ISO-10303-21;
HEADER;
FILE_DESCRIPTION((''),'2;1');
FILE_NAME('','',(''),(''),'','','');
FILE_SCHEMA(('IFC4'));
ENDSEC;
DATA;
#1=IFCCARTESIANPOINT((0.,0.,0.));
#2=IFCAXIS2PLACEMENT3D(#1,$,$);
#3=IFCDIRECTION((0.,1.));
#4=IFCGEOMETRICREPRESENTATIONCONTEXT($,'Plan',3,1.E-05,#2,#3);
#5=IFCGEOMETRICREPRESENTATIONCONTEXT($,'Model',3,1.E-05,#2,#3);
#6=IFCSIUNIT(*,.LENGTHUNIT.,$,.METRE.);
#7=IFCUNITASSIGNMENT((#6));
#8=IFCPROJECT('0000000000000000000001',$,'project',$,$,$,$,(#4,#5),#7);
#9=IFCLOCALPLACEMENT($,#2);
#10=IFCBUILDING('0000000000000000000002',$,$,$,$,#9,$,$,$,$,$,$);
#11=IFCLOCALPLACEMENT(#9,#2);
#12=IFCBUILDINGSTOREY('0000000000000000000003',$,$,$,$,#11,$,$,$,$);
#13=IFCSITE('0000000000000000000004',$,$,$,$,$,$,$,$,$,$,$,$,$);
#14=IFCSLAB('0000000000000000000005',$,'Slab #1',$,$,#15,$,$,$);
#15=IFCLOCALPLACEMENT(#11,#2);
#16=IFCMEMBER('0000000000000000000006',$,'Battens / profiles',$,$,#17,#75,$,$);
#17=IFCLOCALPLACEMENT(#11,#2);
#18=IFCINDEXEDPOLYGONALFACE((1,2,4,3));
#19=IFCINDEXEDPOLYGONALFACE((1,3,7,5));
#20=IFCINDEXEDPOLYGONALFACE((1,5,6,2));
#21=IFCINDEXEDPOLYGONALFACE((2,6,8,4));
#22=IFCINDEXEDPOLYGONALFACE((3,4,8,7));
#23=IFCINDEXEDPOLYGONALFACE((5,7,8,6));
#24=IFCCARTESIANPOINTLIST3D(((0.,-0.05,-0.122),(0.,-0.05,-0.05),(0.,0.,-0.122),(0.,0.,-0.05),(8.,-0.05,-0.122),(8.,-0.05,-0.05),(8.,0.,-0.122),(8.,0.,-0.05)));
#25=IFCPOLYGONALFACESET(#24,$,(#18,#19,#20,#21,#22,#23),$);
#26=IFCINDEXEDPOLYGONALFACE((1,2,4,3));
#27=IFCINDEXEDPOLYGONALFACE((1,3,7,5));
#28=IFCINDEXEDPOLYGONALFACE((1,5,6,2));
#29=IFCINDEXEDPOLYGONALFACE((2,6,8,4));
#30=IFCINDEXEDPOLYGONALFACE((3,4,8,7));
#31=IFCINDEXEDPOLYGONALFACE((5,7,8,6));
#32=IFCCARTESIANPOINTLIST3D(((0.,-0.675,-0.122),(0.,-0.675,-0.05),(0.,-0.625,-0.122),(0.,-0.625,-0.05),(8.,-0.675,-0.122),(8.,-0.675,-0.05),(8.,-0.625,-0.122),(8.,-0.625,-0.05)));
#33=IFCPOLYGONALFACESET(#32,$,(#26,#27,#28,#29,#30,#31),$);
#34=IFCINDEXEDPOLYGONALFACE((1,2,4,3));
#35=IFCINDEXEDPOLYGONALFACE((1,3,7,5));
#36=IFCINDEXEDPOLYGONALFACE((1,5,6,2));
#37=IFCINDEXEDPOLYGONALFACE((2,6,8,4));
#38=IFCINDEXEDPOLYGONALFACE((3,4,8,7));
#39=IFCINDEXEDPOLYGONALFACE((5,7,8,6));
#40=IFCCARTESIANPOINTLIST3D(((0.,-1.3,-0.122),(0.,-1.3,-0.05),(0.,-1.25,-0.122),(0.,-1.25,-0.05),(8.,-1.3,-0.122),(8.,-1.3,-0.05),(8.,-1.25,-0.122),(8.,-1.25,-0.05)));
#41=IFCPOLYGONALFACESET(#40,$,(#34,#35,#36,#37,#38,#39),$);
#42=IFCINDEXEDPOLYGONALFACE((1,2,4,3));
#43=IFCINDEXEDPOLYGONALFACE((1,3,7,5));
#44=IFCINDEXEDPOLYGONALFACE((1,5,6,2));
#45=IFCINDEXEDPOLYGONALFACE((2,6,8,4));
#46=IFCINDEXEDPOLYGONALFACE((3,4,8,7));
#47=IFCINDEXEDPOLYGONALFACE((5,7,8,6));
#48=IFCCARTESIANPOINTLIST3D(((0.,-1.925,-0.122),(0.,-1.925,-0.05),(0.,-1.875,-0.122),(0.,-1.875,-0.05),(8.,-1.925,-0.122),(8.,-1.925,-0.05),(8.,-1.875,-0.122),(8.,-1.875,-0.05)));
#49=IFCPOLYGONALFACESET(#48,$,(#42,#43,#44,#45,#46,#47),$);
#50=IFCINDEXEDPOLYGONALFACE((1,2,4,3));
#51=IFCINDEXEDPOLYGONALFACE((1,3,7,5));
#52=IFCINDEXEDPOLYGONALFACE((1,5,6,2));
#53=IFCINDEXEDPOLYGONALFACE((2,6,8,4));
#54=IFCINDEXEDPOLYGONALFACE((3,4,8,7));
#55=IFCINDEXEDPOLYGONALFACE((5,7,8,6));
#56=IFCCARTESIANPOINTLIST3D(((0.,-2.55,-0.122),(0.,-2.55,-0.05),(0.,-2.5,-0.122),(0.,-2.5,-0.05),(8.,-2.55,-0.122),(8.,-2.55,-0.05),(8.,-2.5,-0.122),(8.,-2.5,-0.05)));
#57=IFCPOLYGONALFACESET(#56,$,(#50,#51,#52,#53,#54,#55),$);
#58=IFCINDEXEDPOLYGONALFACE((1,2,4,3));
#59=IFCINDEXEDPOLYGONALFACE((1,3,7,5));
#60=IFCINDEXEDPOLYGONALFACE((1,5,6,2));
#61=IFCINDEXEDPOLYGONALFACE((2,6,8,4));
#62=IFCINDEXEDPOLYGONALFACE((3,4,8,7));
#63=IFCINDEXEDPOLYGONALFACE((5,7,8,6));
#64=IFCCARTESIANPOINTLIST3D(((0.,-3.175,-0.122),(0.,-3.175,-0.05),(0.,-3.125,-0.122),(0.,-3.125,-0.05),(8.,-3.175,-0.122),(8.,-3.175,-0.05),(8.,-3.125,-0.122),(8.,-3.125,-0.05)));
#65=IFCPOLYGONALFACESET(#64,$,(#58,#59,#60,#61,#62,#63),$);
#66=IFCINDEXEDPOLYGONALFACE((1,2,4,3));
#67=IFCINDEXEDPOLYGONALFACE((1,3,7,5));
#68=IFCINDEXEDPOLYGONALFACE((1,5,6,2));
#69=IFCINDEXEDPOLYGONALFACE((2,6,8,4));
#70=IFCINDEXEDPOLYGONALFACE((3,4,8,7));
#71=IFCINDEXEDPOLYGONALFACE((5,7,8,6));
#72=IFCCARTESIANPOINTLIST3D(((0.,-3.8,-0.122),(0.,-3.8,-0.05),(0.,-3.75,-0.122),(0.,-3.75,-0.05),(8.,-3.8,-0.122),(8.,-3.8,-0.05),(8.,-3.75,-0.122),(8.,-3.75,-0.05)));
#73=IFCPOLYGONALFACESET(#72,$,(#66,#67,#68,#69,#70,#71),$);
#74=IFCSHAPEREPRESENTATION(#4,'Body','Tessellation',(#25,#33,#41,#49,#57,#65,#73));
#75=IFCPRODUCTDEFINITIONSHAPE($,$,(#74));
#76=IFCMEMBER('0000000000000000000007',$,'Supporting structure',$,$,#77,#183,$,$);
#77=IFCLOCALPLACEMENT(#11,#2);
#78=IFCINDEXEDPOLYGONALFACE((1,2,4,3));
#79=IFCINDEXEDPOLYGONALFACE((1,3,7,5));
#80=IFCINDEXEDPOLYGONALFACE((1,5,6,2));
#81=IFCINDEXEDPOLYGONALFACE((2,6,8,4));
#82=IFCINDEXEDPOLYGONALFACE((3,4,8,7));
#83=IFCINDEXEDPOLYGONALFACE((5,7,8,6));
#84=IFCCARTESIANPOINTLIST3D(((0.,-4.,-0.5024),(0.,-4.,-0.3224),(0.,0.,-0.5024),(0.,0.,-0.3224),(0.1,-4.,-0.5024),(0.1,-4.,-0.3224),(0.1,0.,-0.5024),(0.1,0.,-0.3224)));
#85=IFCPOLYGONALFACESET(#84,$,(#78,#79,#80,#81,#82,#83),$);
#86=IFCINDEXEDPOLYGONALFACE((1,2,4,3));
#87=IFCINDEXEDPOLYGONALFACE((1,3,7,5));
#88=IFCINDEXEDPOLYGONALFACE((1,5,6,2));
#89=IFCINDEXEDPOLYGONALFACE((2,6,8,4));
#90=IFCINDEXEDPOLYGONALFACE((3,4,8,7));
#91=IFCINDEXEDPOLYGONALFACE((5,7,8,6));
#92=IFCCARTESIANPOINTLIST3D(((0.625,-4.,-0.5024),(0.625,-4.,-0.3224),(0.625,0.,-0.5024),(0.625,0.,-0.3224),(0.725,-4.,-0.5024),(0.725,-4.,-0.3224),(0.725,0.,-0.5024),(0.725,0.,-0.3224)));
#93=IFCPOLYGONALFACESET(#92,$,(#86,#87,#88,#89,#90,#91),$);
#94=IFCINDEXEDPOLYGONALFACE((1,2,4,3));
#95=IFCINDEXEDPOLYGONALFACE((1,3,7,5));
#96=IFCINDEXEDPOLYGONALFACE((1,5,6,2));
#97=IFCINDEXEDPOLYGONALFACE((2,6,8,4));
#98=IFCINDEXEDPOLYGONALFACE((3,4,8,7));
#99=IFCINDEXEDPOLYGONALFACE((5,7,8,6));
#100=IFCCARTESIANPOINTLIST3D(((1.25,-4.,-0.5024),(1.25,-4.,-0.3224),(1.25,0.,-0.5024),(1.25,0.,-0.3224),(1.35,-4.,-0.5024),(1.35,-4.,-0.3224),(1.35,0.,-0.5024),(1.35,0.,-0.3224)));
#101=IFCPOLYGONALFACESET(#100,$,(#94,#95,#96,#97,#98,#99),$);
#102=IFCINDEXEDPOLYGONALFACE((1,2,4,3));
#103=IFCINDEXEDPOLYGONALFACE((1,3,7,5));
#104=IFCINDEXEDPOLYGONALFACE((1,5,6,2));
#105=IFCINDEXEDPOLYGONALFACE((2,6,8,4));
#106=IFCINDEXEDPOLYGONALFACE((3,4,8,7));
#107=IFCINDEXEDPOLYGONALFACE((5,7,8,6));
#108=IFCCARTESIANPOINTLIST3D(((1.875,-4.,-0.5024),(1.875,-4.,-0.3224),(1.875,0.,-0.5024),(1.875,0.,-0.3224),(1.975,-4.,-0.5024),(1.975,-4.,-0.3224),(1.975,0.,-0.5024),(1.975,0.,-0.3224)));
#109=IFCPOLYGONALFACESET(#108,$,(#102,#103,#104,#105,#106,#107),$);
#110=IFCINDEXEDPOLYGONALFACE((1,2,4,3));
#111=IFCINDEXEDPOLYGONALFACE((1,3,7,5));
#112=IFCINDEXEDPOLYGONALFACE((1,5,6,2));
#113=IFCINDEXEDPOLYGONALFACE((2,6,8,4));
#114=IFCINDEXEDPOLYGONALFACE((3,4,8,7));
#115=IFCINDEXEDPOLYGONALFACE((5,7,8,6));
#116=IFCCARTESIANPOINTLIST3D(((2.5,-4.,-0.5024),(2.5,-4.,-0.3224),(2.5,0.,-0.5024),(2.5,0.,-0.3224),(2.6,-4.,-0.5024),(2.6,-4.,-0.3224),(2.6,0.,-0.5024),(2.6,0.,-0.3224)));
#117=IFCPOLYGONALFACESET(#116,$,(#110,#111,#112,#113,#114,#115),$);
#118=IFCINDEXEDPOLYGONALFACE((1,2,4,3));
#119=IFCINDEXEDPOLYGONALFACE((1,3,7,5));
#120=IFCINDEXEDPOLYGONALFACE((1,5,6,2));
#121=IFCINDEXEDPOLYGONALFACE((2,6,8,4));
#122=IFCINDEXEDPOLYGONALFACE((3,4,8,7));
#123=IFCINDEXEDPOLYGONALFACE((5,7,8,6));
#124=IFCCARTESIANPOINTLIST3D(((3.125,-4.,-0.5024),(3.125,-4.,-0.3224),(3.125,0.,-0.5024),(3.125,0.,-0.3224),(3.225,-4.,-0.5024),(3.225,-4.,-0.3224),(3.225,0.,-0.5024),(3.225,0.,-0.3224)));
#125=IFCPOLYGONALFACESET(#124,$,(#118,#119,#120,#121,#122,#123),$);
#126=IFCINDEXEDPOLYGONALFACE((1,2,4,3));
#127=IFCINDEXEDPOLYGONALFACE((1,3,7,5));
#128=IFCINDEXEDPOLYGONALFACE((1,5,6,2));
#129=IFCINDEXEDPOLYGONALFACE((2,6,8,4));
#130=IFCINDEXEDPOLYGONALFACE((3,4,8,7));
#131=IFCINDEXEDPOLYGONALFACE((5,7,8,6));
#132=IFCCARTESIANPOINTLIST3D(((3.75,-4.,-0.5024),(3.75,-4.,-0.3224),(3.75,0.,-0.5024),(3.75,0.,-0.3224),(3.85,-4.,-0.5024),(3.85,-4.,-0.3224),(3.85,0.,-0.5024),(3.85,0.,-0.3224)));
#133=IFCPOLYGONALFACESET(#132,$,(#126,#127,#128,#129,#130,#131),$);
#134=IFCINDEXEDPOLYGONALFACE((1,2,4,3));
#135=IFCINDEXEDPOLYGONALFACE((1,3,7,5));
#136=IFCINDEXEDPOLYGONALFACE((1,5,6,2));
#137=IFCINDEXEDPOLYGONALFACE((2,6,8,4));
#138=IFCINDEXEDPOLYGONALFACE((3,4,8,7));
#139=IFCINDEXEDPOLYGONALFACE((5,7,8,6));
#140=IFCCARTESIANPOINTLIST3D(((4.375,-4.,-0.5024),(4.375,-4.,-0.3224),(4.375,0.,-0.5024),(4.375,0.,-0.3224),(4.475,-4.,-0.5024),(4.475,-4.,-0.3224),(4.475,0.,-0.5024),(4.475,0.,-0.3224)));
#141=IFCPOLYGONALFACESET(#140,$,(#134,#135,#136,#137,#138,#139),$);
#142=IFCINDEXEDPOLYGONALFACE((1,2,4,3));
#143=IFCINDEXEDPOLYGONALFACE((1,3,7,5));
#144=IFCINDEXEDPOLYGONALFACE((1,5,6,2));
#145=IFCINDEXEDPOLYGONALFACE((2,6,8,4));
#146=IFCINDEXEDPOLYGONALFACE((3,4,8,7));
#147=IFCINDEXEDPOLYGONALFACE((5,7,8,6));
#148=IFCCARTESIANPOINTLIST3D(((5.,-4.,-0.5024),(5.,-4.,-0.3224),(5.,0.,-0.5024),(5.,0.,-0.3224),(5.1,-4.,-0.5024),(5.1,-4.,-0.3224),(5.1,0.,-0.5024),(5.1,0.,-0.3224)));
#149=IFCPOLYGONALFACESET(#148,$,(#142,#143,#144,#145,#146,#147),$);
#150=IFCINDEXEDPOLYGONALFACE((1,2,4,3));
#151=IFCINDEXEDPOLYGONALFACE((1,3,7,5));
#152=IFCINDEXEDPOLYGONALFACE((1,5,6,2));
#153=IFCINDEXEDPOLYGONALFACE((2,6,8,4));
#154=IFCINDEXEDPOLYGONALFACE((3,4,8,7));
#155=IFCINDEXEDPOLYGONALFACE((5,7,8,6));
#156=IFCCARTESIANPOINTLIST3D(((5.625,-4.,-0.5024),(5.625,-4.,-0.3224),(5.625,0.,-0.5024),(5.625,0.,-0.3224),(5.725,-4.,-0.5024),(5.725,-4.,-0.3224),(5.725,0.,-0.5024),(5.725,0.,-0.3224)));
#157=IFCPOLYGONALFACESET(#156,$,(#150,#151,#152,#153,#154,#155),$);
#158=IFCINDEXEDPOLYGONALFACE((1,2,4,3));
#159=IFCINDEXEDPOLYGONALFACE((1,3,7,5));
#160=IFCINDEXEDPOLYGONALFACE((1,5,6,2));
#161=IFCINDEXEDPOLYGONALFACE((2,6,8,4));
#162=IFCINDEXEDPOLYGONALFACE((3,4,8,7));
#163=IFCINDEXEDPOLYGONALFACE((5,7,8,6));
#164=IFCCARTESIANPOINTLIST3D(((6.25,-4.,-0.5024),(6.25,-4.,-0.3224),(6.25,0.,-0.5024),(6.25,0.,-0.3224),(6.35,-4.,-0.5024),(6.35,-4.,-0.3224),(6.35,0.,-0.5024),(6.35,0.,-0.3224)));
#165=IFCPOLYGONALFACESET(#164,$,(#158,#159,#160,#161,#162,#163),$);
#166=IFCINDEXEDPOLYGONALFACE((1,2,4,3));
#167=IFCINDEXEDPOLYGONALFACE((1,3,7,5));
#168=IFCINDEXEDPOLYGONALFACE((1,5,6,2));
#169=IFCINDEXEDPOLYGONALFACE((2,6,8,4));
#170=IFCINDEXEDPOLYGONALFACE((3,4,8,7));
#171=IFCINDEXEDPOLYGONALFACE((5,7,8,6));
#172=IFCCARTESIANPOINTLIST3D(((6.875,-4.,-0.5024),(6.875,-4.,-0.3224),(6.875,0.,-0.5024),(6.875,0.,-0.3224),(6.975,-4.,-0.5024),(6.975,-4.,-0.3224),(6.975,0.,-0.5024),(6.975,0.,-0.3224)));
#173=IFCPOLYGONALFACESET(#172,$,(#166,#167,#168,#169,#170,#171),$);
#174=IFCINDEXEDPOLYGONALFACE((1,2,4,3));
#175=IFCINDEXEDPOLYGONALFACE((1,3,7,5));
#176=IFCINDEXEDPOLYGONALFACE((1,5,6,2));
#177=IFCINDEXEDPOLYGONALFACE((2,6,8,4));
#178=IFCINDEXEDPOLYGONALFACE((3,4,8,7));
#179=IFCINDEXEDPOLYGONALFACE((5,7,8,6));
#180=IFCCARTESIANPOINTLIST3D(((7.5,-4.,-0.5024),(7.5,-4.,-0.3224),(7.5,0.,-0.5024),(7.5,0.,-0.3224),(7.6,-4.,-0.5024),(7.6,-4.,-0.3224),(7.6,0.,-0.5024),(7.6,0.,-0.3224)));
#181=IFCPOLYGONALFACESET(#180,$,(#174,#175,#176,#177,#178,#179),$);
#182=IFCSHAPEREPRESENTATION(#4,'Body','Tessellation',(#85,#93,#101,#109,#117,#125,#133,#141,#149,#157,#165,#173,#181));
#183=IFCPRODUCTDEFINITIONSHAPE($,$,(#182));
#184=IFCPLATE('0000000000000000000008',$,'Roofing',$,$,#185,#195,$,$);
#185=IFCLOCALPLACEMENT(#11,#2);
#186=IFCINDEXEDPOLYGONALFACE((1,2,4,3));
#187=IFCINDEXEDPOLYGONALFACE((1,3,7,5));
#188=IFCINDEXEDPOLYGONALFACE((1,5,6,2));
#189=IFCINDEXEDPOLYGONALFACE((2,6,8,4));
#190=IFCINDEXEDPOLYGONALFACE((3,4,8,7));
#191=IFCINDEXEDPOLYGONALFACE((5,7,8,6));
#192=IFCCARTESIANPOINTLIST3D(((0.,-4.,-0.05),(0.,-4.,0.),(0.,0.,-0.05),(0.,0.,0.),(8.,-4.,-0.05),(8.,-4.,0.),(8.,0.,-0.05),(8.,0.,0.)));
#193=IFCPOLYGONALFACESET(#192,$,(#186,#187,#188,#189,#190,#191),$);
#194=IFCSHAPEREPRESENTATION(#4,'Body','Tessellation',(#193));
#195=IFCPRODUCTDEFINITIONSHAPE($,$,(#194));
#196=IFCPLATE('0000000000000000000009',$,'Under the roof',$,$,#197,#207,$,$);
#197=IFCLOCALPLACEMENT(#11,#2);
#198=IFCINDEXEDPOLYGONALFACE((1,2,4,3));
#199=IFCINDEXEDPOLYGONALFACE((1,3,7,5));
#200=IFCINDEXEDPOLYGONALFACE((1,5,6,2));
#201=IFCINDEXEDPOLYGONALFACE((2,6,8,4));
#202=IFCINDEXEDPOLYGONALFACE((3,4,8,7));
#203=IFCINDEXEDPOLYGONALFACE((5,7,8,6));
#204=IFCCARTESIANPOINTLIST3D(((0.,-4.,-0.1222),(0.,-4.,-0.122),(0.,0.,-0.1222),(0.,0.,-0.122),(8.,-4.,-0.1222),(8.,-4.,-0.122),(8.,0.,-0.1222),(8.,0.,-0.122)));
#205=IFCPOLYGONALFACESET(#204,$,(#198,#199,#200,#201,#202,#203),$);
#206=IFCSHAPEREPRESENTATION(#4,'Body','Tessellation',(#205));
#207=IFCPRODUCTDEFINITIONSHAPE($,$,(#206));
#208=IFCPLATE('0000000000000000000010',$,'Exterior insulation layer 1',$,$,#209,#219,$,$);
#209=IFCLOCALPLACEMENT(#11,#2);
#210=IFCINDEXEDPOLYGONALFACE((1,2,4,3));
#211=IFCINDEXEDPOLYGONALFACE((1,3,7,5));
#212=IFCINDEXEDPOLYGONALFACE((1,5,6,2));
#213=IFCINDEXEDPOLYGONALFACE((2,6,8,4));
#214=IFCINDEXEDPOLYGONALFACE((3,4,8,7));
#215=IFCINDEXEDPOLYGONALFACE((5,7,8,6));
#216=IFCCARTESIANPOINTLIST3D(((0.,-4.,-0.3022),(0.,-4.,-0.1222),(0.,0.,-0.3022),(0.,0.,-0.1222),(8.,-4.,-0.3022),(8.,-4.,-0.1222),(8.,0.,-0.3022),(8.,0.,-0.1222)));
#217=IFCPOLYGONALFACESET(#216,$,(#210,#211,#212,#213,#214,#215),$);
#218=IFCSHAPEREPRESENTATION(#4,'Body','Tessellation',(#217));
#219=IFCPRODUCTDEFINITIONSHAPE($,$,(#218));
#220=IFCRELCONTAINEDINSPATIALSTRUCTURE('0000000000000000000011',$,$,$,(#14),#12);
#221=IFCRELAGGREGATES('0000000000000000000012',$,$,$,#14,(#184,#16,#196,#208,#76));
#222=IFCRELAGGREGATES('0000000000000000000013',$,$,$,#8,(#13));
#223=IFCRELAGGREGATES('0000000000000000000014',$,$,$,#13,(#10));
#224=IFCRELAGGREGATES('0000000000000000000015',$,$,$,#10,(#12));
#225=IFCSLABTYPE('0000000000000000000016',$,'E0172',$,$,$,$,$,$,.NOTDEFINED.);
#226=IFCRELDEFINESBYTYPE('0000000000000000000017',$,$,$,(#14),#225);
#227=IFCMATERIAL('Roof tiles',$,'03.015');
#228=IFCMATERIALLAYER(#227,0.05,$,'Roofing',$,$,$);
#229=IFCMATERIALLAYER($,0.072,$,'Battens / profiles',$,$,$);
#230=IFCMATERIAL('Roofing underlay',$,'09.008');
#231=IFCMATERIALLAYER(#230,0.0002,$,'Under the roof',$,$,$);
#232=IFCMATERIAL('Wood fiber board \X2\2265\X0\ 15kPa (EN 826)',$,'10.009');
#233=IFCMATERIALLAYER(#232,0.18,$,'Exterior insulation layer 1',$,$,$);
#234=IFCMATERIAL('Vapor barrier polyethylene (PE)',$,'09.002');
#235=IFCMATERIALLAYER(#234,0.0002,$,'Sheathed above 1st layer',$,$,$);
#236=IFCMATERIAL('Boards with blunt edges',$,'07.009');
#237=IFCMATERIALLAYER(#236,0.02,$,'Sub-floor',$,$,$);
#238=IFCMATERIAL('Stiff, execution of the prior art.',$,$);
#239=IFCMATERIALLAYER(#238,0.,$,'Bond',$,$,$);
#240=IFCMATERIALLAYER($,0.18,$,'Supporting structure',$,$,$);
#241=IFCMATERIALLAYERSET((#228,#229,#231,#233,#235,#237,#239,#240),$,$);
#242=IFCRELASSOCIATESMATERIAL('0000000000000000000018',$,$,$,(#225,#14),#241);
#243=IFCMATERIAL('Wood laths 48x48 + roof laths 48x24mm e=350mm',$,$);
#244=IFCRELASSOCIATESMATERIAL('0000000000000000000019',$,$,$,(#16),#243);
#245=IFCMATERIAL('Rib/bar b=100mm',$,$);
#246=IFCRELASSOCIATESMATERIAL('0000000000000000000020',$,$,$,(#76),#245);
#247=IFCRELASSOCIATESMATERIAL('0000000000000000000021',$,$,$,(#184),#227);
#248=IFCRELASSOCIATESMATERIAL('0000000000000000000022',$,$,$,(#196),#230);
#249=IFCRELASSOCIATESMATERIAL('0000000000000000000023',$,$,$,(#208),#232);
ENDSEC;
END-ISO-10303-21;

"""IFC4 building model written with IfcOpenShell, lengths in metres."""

from ifc_helpers import new_model, si_unit, direction, frame, frame_2d, origin, origin_with_axes, place, context, project, spatial, rectangle, extrude, material, layer, layer_set, type_object, element, aggregate, save


model = new_model("IFC4")

# Units and contexts
plan_context = context("Plan", 3, precision=1e-05, world=origin(), true_north=direction((0.0, 1.0)))
model_context = context("Model", 3, precision=1e-05, world=origin(), true_north=direction((0.0, 1.0)))
ifc_project = project(units=[si_unit("LENGTHUNIT", "METRE")], contexts=[plan_context, model_context])

# Site, building, storey
site = spatial("IfcSite", under=ifc_project)
building_placement = place(None, origin())
building = spatial("IfcBuilding", under=site, at=building_placement)
storey_placement = place(building_placement, origin())
storey = spatial("IfcBuildingStorey", under=building, at=storey_placement)

# Slab, members, plates
ifc_material_1 = material(Name="Roof tiles", Category="03.015")
ifc_layer_1 = layer(ifc_material_1, 0.05, Name="Roofing")
ifc_layer_2 = layer(None, 0.072, Name="Battens / profiles")
ifc_material_2 = material(Name="Roofing underlay", Category="09.008")
ifc_layer_3 = layer(ifc_material_2, 0.0002, Name="Under the roof")
ifc_material_3 = material(Name="Wood fiber board ≥ 15kPa (EN 826)", Category="10.009")
ifc_layer_4 = layer(ifc_material_3, 0.18, Name="Exterior insulation layer 1")
ifc_material_4 = material(Name="Vapor barrier polyethylene (PE)", Category="09.002")
ifc_layer_5 = layer(ifc_material_4, 0.0002, Name="Sheathed above 1st layer")
ifc_material_5 = material(Name="Boards with blunt edges", Category="07.009")
ifc_layer_6 = layer(ifc_material_5, 0.02, Name="Sub-floor")
ifc_material_6 = material(Name="Stiff, execution of the prior art.")
ifc_layer_7 = layer(ifc_material_6, 0.0, Name="Bond")
ifc_layer_8 = layer(None, 0.18, Name="Supporting structure")
ifc_layer_set = layer_set([ifc_layer_1, ifc_layer_2, ifc_layer_3, ifc_layer_4, ifc_layer_5, ifc_layer_6, ifc_layer_7, ifc_layer_8])
slab_type = type_object("IfcSlabType", Name="E0172", PredefinedType="NOTDEFINED", material=ifc_layer_set)
slab_placement = place(None, frame((0.0, 0.0, 0.0), z_axis=(0.0, 0.0, -1.0), x_axis=(1.0, 0.0, 0.0)))
slab = element("IfcSlab", 1, at=slab_placement, inside=storey, type_object=slab_type, material=ifc_layer_set, Name="Slab #1")
ifc_material_7 = material(Name="Wood laths 48x48 + roof laths 48x24mm e=350mm")
member_1_placement = place(slab_placement, origin())
member_1 = element("IfcMember", 2, at=member_1_placement, material=ifc_material_7, Name="Battens / profiles", context=plan_context, shape_type="SweptSolid", body=[
    extrude(rectangle(XDim=0.05, YDim=0.072, at=frame_2d((0.025, 0.036), x_axis=(1.0, 0.0))), frame((0.0, 0.0, 0.05), z_axis=(1.0, 0.0, 0.0), x_axis=(0.0, 1.0, 0.0)), (0.0, 0.0, 1.0), 8.0),
    extrude(rectangle(XDim=0.05, YDim=0.072, at=frame_2d((0.025, 0.036), x_axis=(1.0, 0.0))), frame((0.0, 0.625, 0.05), z_axis=(1.0, 0.0, 0.0), x_axis=(0.0, 1.0, 0.0)), (0.0, 0.0, 1.0), 8.0),
    extrude(rectangle(XDim=0.05, YDim=0.072, at=frame_2d((0.025, 0.036), x_axis=(1.0, 0.0))), frame((0.0, 1.25, 0.05), z_axis=(1.0, 0.0, 0.0), x_axis=(0.0, 1.0, 0.0)), (0.0, 0.0, 1.0), 8.0),
    extrude(rectangle(XDim=0.05, YDim=0.072, at=frame_2d((0.025, 0.036), x_axis=(1.0, 0.0))), frame((0.0, 1.875, 0.05), z_axis=(1.0, 0.0, 0.0), x_axis=(0.0, 1.0, 0.0)), (0.0, 0.0, 1.0), 8.0),
    extrude(rectangle(XDim=0.05, YDim=0.072, at=frame_2d((0.025, 0.036), x_axis=(1.0, 0.0))), frame((0.0, 2.5, 0.05), z_axis=(1.0, 0.0, 0.0), x_axis=(0.0, 1.0, 0.0)), (0.0, 0.0, 1.0), 8.0),
    extrude(rectangle(XDim=0.05, YDim=0.072, at=frame_2d((0.025, 0.036), x_axis=(1.0, 0.0))), frame((0.0, 3.125, 0.05), z_axis=(1.0, 0.0, 0.0), x_axis=(0.0, 1.0, 0.0)), (0.0, 0.0, 1.0), 8.0),
    extrude(rectangle(XDim=0.05, YDim=0.072, at=frame_2d((0.025, 0.036), x_axis=(1.0, 0.0))), frame((0.0, 3.75, 0.05), z_axis=(1.0, 0.0, 0.0), x_axis=(0.0, 1.0, 0.0)), (0.0, 0.0, 1.0), 8.0),
])
ifc_material_8 = material(Name="Rib/bar b=100mm")
member_2_placement = place(slab_placement, origin())
member_2 = element("IfcMember", 3, at=member_2_placement, material=ifc_material_8, Name="Supporting structure", context=plan_context, shape_type="SweptSolid", body=[
    extrude(rectangle(XDim=0.1, YDim=0.18, at=frame_2d((0.05, 0.09), x_axis=(1.0, 0.0))), frame((0.0, 4.0, 0.3224), z_axis=(0.0, -1.0, 0.0), x_axis=(1.0, 0.0, 0.0)), (0.0, 0.0, 1.0), 4.0),
    extrude(rectangle(XDim=0.1, YDim=0.18, at=frame_2d((0.05, 0.09), x_axis=(1.0, 0.0))), frame((0.625, 4.0, 0.3224), z_axis=(0.0, -1.0, 0.0), x_axis=(1.0, 0.0, 0.0)), (0.0, 0.0, 1.0), 4.0),
    extrude(rectangle(XDim=0.1, YDim=0.18, at=frame_2d((0.05, 0.09), x_axis=(1.0, 0.0))), frame((1.25, 4.0, 0.3224), z_axis=(0.0, -1.0, 0.0), x_axis=(1.0, 0.0, 0.0)), (0.0, 0.0, 1.0), 4.0),
    extrude(rectangle(XDim=0.1, YDim=0.18, at=frame_2d((0.05, 0.09), x_axis=(1.0, 0.0))), frame((1.875, 4.0, 0.3224), z_axis=(0.0, -1.0, 0.0), x_axis=(1.0, 0.0, 0.0)), (0.0, 0.0, 1.0), 4.0),
    extrude(rectangle(XDim=0.1, YDim=0.18, at=frame_2d((0.05, 0.09), x_axis=(1.0, 0.0))), frame((2.5, 4.0, 0.3224), z_axis=(0.0, -1.0, 0.0), x_axis=(1.0, 0.0, 0.0)), (0.0, 0.0, 1.0), 4.0),
    extrude(rectangle(XDim=0.1, YDim=0.18, at=frame_2d((0.05, 0.09), x_axis=(1.0, 0.0))), frame((3.125, 4.0, 0.3224), z_axis=(0.0, -1.0, 0.0), x_axis=(1.0, 0.0, 0.0)), (0.0, 0.0, 1.0), 4.0),
    extrude(rectangle(XDim=0.1, YDim=0.18, at=frame_2d((0.05, 0.09), x_axis=(1.0, 0.0))), frame((3.75, 4.0, 0.3224), z_axis=(0.0, -1.0, 0.0), x_axis=(1.0, 0.0, 0.0)), (0.0, 0.0, 1.0), 4.0),
    extrude(rectangle(XDim=0.1, YDim=0.18, at=frame_2d((0.05, 0.09), x_axis=(1.0, 0.0))), frame((4.375, 4.0, 0.3224), z_axis=(0.0, -1.0, 0.0), x_axis=(1.0, 0.0, 0.0)), (0.0, 0.0, 1.0), 4.0),
    extrude(rectangle(XDim=0.1, YDim=0.18, at=frame_2d((0.05, 0.09), x_axis=(1.0, 0.0))), frame((5.0, 4.0, 0.3224), z_axis=(0.0, -1.0, 0.0), x_axis=(1.0, 0.0, 0.0)), (0.0, 0.0, 1.0), 4.0),
    extrude(rectangle(XDim=0.1, YDim=0.18, at=frame_2d((0.05, 0.09), x_axis=(1.0, 0.0))), frame((5.625, 4.0, 0.3224), z_axis=(0.0, -1.0, 0.0), x_axis=(1.0, 0.0, 0.0)), (0.0, 0.0, 1.0), 4.0),
    extrude(rectangle(XDim=0.1, YDim=0.18, at=frame_2d((0.05, 0.09), x_axis=(1.0, 0.0))), frame((6.25, 4.0, 0.3224), z_axis=(0.0, -1.0, 0.0), x_axis=(1.0, 0.0, 0.0)), (0.0, 0.0, 1.0), 4.0),
    extrude(rectangle(XDim=0.1, YDim=0.18, at=frame_2d((0.05, 0.09), x_axis=(1.0, 0.0))), frame((6.875, 4.0, 0.3224), z_axis=(0.0, -1.0, 0.0), x_axis=(1.0, 0.0, 0.0)), (0.0, 0.0, 1.0), 4.0),
    extrude(rectangle(XDim=0.1, YDim=0.18, at=frame_2d((0.05, 0.09), x_axis=(1.0, 0.0))), frame((7.5, 4.0, 0.3224), z_axis=(0.0, -1.0, 0.0), x_axis=(1.0, 0.0, 0.0)), (0.0, 0.0, 1.0), 4.0),
])
plate_1_placement = place(slab_placement, origin())
plate_1 = element("IfcPlate", 4, at=plate_1_placement, material=ifc_material_1, Name="Roofing", context=plan_context, shape_type="SweptSolid", body=[
    extrude(rectangle(XDim=8.0, YDim=4.0, at=frame_2d((4.0, 2.0), x_axis=(1.0, 0.0))), origin_with_axes(), (0.0, 0.0, 1.0), 0.05),
])
plate_2_placement = place(slab_placement, origin())
plate_2 = element("IfcPlate", 5, at=plate_2_placement, material=ifc_material_2, Name="Under the roof", context=plan_context, shape_type="SweptSolid", body=[
    extrude(rectangle(XDim=8.0, YDim=4.0, at=frame_2d((4.0, 2.0), x_axis=(1.0, 0.0))), frame((0.0, 0.0, 0.122), z_axis=(0.0, 0.0, 1.0), x_axis=(1.0, 0.0, 0.0)), (0.0, 0.0, 1.0), 0.0002),
])
plate_3_placement = place(slab_placement, origin())
plate_3 = element("IfcPlate", 6, at=plate_3_placement, material=ifc_material_3, Name="Exterior insulation layer 1", context=plan_context, shape_type="SweptSolid", body=[
    extrude(rectangle(XDim=8.0, YDim=4.0, at=frame_2d((4.0, 2.0), x_axis=(1.0, 0.0))), frame((0.0, 0.0, 0.1222), z_axis=(0.0, 0.0, 1.0), x_axis=(1.0, 0.0, 0.0)), (0.0, 0.0, 1.0), 0.18),
])
aggregate(slab, [plate_1, member_1, plate_2, plate_3, member_2])

save(model, "model.ifc")
